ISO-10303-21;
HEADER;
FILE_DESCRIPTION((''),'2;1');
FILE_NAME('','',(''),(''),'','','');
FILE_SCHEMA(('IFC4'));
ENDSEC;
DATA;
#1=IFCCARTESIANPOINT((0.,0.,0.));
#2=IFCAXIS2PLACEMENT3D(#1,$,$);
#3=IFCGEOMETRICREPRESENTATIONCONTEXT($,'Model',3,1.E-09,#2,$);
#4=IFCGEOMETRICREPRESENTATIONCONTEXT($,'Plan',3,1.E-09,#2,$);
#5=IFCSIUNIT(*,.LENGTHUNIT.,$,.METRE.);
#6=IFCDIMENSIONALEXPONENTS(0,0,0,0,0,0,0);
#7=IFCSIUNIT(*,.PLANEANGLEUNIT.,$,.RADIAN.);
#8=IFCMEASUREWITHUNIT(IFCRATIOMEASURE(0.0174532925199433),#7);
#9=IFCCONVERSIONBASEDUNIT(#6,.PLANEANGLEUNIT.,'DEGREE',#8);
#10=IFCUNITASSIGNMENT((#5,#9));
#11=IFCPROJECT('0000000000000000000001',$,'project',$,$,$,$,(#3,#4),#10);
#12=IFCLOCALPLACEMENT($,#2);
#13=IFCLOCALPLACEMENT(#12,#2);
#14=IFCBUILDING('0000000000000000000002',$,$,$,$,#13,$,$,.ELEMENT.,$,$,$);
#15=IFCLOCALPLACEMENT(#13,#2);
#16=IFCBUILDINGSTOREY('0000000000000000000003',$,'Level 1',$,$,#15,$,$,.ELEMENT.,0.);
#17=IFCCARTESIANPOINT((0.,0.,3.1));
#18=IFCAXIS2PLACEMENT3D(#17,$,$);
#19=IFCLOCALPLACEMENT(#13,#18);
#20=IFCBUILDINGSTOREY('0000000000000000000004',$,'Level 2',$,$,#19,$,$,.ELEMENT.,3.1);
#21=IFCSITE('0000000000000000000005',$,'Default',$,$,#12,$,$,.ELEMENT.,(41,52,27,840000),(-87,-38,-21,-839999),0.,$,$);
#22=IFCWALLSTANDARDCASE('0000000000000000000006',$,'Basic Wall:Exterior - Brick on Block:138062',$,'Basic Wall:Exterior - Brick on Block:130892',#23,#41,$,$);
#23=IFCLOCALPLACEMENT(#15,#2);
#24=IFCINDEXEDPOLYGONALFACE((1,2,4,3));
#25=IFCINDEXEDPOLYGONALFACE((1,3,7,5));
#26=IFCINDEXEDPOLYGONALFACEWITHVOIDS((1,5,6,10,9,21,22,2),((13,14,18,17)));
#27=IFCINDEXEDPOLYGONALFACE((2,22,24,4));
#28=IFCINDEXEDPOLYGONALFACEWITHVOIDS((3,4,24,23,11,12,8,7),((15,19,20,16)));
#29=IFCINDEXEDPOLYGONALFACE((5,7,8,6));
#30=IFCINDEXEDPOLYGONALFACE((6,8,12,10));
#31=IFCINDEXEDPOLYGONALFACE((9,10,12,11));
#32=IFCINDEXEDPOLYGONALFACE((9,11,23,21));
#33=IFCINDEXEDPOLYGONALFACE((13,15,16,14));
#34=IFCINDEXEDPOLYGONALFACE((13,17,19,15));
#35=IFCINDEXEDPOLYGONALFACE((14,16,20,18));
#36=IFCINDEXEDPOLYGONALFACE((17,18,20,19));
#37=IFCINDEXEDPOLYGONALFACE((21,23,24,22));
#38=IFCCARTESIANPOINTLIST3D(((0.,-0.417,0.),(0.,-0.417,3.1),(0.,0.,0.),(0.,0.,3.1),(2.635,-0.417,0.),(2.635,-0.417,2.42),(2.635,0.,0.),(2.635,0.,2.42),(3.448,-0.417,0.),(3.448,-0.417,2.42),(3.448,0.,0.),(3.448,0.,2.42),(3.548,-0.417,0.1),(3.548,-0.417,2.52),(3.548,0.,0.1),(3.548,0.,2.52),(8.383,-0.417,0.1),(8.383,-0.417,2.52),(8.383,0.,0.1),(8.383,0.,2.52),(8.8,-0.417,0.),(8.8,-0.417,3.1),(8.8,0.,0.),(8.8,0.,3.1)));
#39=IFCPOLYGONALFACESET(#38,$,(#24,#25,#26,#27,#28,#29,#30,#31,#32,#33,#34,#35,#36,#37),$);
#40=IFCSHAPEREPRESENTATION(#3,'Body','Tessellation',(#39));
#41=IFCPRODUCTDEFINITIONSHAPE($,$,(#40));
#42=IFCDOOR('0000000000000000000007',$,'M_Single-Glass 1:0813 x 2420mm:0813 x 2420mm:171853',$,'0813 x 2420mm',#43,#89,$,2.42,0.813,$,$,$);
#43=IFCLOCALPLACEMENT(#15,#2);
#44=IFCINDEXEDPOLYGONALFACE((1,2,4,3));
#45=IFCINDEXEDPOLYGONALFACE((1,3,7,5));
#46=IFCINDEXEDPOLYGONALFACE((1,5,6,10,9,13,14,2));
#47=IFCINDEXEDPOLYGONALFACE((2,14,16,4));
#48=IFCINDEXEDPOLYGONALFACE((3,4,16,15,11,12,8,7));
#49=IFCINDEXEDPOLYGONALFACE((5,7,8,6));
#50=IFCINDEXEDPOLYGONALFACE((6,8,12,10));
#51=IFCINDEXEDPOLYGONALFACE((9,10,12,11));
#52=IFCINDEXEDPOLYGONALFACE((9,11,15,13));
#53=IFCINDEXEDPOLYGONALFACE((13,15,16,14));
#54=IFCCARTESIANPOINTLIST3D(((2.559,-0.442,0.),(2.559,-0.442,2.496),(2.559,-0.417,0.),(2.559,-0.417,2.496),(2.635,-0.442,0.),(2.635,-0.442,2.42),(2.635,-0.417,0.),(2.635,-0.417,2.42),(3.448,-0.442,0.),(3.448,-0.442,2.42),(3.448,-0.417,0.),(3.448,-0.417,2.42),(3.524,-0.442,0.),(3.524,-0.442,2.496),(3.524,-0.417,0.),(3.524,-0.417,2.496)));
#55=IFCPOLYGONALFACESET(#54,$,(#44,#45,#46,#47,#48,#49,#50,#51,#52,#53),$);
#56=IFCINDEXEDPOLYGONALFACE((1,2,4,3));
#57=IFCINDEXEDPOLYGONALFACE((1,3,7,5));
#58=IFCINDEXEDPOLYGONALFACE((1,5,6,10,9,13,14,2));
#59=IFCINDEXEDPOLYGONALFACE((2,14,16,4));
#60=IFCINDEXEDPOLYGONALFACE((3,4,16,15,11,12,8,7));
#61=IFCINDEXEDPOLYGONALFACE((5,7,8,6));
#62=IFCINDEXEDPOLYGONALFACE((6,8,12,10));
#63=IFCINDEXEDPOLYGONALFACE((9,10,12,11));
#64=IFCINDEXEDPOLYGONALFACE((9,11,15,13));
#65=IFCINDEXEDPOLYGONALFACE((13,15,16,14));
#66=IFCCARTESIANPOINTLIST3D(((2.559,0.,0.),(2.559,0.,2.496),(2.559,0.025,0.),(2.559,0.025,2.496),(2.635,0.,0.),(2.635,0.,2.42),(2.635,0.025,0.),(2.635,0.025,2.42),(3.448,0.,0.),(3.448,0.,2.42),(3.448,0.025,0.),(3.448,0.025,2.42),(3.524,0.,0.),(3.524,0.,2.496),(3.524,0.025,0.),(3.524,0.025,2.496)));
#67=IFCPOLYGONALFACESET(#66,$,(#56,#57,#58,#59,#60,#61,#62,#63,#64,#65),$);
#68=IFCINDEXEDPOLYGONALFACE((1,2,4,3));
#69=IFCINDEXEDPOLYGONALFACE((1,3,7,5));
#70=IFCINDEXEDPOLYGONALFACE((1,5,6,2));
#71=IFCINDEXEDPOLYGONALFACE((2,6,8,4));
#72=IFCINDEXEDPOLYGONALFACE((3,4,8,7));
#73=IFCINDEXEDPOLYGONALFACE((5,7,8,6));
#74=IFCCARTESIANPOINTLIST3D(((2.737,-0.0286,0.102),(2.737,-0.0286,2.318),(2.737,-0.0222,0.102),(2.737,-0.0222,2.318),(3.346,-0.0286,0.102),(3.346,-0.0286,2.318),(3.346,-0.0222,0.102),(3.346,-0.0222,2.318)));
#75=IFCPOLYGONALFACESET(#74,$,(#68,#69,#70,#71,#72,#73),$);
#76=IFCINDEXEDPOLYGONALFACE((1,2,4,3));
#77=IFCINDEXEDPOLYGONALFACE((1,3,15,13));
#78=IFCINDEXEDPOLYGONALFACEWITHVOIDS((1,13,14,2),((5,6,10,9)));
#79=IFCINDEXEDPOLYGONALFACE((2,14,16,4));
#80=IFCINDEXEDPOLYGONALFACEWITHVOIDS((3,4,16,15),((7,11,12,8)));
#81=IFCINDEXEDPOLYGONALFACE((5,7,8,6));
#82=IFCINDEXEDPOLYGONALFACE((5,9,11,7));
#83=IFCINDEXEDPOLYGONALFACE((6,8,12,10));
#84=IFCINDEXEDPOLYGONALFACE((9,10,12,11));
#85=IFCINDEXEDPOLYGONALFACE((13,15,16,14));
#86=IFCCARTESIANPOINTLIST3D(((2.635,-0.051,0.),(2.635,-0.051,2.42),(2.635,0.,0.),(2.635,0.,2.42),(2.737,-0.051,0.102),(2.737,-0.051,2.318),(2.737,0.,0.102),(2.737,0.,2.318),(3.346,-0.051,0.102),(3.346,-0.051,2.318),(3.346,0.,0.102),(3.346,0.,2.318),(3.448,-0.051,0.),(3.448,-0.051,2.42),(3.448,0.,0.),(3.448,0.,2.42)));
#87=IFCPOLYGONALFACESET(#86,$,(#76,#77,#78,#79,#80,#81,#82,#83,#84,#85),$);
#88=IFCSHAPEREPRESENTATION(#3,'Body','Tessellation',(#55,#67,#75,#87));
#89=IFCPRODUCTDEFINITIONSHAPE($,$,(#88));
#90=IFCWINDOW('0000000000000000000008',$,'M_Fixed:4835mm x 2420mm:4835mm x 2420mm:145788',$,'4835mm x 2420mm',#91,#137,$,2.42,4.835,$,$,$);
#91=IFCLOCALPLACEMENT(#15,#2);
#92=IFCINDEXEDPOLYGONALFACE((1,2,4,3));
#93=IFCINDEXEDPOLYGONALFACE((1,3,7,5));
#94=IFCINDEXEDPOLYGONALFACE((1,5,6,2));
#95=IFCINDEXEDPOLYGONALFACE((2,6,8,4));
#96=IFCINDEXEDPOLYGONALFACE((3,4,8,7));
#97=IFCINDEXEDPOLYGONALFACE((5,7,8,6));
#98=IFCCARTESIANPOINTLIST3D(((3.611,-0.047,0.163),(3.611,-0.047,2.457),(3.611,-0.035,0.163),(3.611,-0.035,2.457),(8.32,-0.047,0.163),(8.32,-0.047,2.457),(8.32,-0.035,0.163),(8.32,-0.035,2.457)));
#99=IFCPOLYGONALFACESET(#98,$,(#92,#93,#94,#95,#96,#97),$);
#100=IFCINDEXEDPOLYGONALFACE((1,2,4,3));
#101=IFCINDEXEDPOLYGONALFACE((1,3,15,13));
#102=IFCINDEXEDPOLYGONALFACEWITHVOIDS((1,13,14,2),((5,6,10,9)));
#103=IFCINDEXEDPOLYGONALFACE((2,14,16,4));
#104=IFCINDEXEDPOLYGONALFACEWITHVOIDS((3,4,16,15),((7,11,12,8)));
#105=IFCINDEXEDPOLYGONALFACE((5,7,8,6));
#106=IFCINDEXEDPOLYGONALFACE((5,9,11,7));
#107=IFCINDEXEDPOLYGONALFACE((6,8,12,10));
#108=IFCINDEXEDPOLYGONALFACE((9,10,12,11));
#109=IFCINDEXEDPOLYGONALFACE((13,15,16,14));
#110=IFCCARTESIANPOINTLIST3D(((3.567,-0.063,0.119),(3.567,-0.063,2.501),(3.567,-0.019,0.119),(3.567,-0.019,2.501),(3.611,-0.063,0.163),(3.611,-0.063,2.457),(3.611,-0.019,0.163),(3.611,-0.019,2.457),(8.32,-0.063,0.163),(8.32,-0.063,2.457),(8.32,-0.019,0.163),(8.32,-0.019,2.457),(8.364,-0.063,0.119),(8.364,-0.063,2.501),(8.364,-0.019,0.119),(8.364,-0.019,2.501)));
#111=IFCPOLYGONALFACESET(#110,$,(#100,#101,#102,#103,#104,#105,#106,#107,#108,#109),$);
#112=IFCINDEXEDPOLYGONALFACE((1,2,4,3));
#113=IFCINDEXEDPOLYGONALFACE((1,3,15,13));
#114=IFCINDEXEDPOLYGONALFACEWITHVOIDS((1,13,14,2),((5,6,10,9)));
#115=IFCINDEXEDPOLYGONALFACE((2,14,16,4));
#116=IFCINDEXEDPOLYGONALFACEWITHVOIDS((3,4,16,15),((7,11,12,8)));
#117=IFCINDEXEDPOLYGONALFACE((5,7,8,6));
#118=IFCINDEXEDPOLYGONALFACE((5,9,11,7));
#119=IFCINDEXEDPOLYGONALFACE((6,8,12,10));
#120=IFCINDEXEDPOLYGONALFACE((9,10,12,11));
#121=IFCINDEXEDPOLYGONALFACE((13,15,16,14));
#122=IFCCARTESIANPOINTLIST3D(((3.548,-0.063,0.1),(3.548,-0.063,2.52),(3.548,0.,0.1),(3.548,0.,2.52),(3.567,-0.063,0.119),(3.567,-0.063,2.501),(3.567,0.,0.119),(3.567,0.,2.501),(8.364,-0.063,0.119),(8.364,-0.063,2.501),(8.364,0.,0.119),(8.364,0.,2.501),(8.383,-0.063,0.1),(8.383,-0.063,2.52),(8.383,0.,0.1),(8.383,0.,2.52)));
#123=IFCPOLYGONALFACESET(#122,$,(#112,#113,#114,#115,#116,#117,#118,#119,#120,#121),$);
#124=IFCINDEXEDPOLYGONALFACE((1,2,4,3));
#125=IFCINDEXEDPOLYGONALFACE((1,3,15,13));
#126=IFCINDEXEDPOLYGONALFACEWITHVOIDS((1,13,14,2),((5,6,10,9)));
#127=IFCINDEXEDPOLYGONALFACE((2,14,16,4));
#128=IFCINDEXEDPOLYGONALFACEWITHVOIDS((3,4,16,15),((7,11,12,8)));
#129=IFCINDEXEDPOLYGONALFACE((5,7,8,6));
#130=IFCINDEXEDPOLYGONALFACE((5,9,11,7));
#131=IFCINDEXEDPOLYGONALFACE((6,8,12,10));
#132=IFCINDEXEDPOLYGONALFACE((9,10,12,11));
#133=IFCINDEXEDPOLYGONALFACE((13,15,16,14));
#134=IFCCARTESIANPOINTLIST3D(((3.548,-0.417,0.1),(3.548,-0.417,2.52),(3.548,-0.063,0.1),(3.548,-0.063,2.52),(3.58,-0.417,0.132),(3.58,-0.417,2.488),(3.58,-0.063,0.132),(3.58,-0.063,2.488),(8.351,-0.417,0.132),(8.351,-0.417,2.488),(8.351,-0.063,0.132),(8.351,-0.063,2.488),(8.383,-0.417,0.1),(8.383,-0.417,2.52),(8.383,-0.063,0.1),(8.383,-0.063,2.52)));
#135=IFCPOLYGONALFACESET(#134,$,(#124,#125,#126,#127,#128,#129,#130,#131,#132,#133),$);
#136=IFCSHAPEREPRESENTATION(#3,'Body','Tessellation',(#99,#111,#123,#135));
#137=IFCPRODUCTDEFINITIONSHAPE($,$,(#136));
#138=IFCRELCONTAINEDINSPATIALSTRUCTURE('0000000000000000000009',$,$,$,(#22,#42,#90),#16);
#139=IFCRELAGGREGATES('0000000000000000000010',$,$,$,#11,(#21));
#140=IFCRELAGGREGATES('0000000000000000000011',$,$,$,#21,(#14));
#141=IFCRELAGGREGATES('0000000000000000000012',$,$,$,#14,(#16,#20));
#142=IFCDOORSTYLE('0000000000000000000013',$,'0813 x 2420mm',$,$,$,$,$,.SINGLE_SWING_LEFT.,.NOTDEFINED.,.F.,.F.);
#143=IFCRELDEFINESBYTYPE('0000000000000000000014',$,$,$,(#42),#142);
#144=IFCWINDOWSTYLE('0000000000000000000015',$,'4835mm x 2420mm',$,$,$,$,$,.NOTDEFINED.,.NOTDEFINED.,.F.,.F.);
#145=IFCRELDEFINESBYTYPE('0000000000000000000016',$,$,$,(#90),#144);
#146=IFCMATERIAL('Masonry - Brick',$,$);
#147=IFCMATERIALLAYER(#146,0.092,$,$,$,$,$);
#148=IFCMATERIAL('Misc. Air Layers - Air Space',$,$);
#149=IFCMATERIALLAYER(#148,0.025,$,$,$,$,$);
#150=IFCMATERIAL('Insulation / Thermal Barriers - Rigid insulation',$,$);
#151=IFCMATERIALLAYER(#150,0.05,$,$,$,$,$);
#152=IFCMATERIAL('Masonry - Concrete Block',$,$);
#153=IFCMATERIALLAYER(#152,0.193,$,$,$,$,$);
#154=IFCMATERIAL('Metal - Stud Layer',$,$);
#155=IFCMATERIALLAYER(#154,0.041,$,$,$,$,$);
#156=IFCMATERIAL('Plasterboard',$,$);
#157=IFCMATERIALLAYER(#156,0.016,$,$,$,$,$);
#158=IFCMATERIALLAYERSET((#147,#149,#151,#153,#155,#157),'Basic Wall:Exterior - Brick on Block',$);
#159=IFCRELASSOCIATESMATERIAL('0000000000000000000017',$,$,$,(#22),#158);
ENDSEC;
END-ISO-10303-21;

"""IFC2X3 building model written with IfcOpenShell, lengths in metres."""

from ifc_helpers import new_model, entity, si_unit, converted_unit, frame, frame_2d, origin, origin_2d_with_axis, place, context, project, spatial, polyline, rectangle, outline, extrude, source, transform, mapped, material, layer, layer_set, layer_usage, type_object, type_shapes, element, fill, save


model = new_model("IFC2X3")

# Units and contexts
model_context = context("Model", 3, precision=1e-09, world=origin())
plan_context = context("Plan", 3, precision=1e-09, world=origin())
ifc_project = project(units=[si_unit("LENGTHUNIT", "METRE"), converted_unit("PLANEANGLEUNIT", "DEGREE", entity("IfcRatioMeasure", 0.0174532925199433), si_unit("PLANEANGLEUNIT", "RADIAN"), dimensions=[0, 0, 0, 0, 0, 0, 0])], contexts=[model_context, plan_context])

# Site, building, storey
site_placement = place(None, origin())
site = spatial("IfcSite", under=ifc_project, at=site_placement, Name="Default", CompositionType="ELEMENT", RefLatitude=(41, 52, 27, 840000), RefLongitude=(-87, -38, -21, -839999), RefElevation=0.0)
building_placement = place(site_placement, origin())
building = spatial("IfcBuilding", under=site, at=building_placement, CompositionType="ELEMENT")
storey_1_placement = place(building_placement, origin())
storey_1 = spatial("IfcBuildingStorey", under=building, at=storey_1_placement, Name="Level 1", CompositionType="ELEMENT", Elevation=0.0)

# Shared definitions
ifc_material_1 = material(Name="Masonry - Brick")
ifc_layer_1 = layer(ifc_material_1, 0.092)
ifc_material_2 = material(Name="Misc. Air Layers - Air Space")
ifc_layer_2 = layer(ifc_material_2, 0.025)
ifc_material_3 = material(Name="Insulation / Thermal Barriers - Rigid insulation")
ifc_layer_3 = layer(ifc_material_3, 0.05)
ifc_material_4 = material(Name="Masonry - Concrete Block")
ifc_layer_4 = layer(ifc_material_4, 0.193)
ifc_material_5 = material(Name="Metal - Stud Layer")
ifc_layer_5 = layer(ifc_material_5, 0.041)
ifc_material_6 = material(Name="Plasterboard")
ifc_layer_6 = layer(ifc_material_6, 0.016)
ifc_layer_set_1 = layer_set([ifc_layer_1, ifc_layer_2, ifc_layer_3, ifc_layer_4, ifc_layer_5, ifc_layer_6], Name="Basic Wall:Exterior - Brick on Block")
ifc_layer_usage_1 = layer_usage(ifc_layer_set_1, "AXIS2", "NEGATIVE", 0.2085)

# Wall, openings, door, window
wall_1_placement = place(storey_1_placement, frame((0.0, -0.2085, 0.0)))
wall_1 = element("IfcWallStandardCase", 1, at=wall_1_placement, inside=storey_1, material=ifc_layer_usage_1, Name="Basic Wall:Exterior - Brick on Block:138062", ObjectType="Basic Wall:Exterior - Brick on Block:130892", context=model_context, shape_type="SweptSolid", body=[
    extrude(rectangle(XDim=8.8, YDim=0.417, at=frame_2d((4.4, 0.0), x_axis=(-1.0, 0.0))), origin(), (0.0, 0.0, 1.0), 3.1),
])
opening_1_placement = place(wall_1_placement, frame((3.548, -0.2085, 0.1)))
opening_1 = element("IfcOpeningElement", 2, at=opening_1_placement, cuts=wall_1, ObjectType="Opening", context=model_context, shape_type="SweptSolid", body=[
    extrude(rectangle(XDim=2.42, YDim=4.835, at=frame_2d((1.21, 2.4175), x_axis=(1.0, 0.0))), frame((0.0, 0.0, 0.0), z_axis=(0.0, 1.0, 0.0), x_axis=(0.0, 0.0, 1.0)), (0.0, 0.0, 1.0), 0.417),
])
opening_2_placement = place(wall_1_placement, frame((2.635, -0.2085, 0.0)))
opening_2 = element("IfcOpeningElement", 3, at=opening_2_placement, cuts=wall_1, ObjectType="Opening", context=model_context, shape_type="SweptSolid", body=[
    extrude(rectangle(XDim=0.813, YDim=2.42, at=frame_2d((1.21, 0.4065), x_axis=(0.0, -1.0))), frame((0.0, 0.0, 0.0), z_axis=(0.0, 1.0, 0.0), x_axis=(0.0, 0.0, 1.0)), (0.0, 0.0, 1.0), 0.417),
])
door_style_1 = type_object("IfcDoorStyle", Name="0813 x 2420mm", ConstructionType="NOTDEFINED", OperationType="SINGLE_SWING_LEFT", ParameterTakesPrecedence=False, Sizeable=False)
shared_shape_1 = source(origin(), model_context, "Body", "SweptSolid", [
    extrude(outline(polyline([(-0.4065, -1.191), (-0.4065, 1.229), (-0.4825, 1.229), (-0.4825, -1.267), (0.4825, -1.267), (0.4825, 1.229), (0.4065, 1.229), (0.4065, -1.191), (-0.4065, -1.191)])), frame((0.4065, 0.0, 1.229), z_axis=(0.0, 1.0, 0.0), x_axis=(1.0, 0.0, 0.0)), (0.0, 0.0, -1.0), 0.025),
    extrude(outline(polyline([(-0.4065, -1.191), (-0.4065, 1.229), (-0.4825, 1.229), (-0.4825, -1.267), (0.4825, -1.267), (0.4825, 1.229), (0.4065, 1.229), (0.4065, -1.191), (-0.4065, -1.191)])), frame((0.4065, 0.442, 1.229), z_axis=(0.0, 1.0, 0.0), x_axis=(1.0, 0.0, 0.0)), (0.0, 0.0, -1.0), 0.025),
    extrude(rectangle(XDim=0.609, YDim=0.0064, at=origin_2d_with_axis()), frame((0.4065, 0.3916, 0.102)), (0.0, 0.0, 1.0), 2.216),
    extrude(outline(polyline([(-1.21, -0.4065), (1.21, -0.4065), (1.21, 0.4065), (-1.21, 0.4065), (-1.21, -0.4065)]), holes=[polyline([(-1.108, 0.3045), (1.108, 0.3045), (1.108, -0.3045), (-1.108, -0.3045), (-1.108, 0.3045)])]), frame((0.4065, 0.417, 1.21), z_axis=(0.0, -1.0, 0.0), x_axis=(0.0, 0.0, -1.0)), (0.0, 0.0, 1.0), 0.051),
])
type_shapes(door_style_1, [shared_shape_1])
door_1_placement = place(opening_2_placement, origin())
door_1 = element("IfcDoor", 4, at=door_1_placement, inside=storey_1, type_object=door_style_1, Name="M_Single-Glass 1:0813 x 2420mm:0813 x 2420mm:171853", ObjectType="0813 x 2420mm", OverallHeight=2.42, OverallWidth=0.813, context=model_context, shape_type="MappedRepresentation", body=[
    mapped(shared_shape_1, transform((0.0, 0.0, 0.0), scale=1.0)),
])
fill(opening_2, door_1)
window_style_1 = type_object("IfcWindowStyle", Name="4835mm x 2420mm", ConstructionType="NOTDEFINED", OperationType="NOTDEFINED", ParameterTakesPrecedence=False, Sizeable=False)
shared_shape_2 = source(origin(), model_context, "Body", "SweptSolid", [
    extrude(rectangle(XDim=0.012, YDim=4.709, at=origin_2d_with_axis()), frame((2.4175, 0.376, 0.063), z_axis=(0.0, 0.0, 1.0), x_axis=(0.0, -1.0, 0.0)), (0.0, 0.0, 1.0), 2.294),
    extrude(outline(polyline([(-2.3985, -1.191), (2.3985, -1.191), (2.3985, 1.191), (-2.3985, 1.191), (-2.3985, -1.191)]), holes=[polyline([(-2.3545, -1.147), (-2.3545, 1.147), (2.3545, 1.147), (2.3545, -1.147), (-2.3545, -1.147)])]), frame((2.4175, 0.354, 1.21), z_axis=(0.0, 1.0, 0.0), x_axis=(1.0, 0.0, 0.0)), (0.0, 0.0, 1.0), 0.044),
    extrude(outline(polyline([(-2.4175, -1.21), (2.4175, -1.21), (2.4175, 1.21), (-2.4175, 1.21), (-2.4175, -1.21)]), holes=[polyline([(-2.3985, -1.191), (-2.3985, 1.191), (2.3985, 1.191), (2.3985, -1.191), (-2.3985, -1.191)])]), frame((2.4175, 0.354, 1.21), z_axis=(0.0, 1.0, 0.0), x_axis=(1.0, 0.0, 0.0)), (0.0, 0.0, 1.0), 0.063),
    extrude(outline(polyline([(-2.4175, -1.21), (2.4175, -1.21), (2.4175, 1.21), (-2.4175, 1.21), (-2.4175, -1.21)]), holes=[polyline([(-2.3855, -1.178), (-2.3855, 1.178), (2.3855, 1.178), (2.3855, -1.178), (-2.3855, -1.178)])]), frame((2.4175, 0.0, 1.21), z_axis=(0.0, 1.0, 0.0), x_axis=(1.0, 0.0, 0.0)), (0.0, 0.0, 1.0), 0.354),
])
type_shapes(window_style_1, [shared_shape_2])
window_1_placement = place(opening_1_placement, origin())
window_1 = element("IfcWindow", 5, at=window_1_placement, inside=storey_1, type_object=window_style_1, Name="M_Fixed:4835mm x 2420mm:4835mm x 2420mm:145788", ObjectType="4835mm x 2420mm", OverallHeight=2.42, OverallWidth=4.835, context=model_context, shape_type="MappedRepresentation", body=[
    mapped(shared_shape_2, transform((0.0, 0.0, 0.0), scale=1.0)),
])
fill(opening_1, window_1)

# Shared definitions
storey_2_placement = place(building_placement, frame((0.0, 0.0, 3.1)))
storey_2 = spatial("IfcBuildingStorey", under=building, at=storey_2_placement, Name="Level 2", CompositionType="ELEMENT", Elevation=3.1)

save(model, "model.ifc")
